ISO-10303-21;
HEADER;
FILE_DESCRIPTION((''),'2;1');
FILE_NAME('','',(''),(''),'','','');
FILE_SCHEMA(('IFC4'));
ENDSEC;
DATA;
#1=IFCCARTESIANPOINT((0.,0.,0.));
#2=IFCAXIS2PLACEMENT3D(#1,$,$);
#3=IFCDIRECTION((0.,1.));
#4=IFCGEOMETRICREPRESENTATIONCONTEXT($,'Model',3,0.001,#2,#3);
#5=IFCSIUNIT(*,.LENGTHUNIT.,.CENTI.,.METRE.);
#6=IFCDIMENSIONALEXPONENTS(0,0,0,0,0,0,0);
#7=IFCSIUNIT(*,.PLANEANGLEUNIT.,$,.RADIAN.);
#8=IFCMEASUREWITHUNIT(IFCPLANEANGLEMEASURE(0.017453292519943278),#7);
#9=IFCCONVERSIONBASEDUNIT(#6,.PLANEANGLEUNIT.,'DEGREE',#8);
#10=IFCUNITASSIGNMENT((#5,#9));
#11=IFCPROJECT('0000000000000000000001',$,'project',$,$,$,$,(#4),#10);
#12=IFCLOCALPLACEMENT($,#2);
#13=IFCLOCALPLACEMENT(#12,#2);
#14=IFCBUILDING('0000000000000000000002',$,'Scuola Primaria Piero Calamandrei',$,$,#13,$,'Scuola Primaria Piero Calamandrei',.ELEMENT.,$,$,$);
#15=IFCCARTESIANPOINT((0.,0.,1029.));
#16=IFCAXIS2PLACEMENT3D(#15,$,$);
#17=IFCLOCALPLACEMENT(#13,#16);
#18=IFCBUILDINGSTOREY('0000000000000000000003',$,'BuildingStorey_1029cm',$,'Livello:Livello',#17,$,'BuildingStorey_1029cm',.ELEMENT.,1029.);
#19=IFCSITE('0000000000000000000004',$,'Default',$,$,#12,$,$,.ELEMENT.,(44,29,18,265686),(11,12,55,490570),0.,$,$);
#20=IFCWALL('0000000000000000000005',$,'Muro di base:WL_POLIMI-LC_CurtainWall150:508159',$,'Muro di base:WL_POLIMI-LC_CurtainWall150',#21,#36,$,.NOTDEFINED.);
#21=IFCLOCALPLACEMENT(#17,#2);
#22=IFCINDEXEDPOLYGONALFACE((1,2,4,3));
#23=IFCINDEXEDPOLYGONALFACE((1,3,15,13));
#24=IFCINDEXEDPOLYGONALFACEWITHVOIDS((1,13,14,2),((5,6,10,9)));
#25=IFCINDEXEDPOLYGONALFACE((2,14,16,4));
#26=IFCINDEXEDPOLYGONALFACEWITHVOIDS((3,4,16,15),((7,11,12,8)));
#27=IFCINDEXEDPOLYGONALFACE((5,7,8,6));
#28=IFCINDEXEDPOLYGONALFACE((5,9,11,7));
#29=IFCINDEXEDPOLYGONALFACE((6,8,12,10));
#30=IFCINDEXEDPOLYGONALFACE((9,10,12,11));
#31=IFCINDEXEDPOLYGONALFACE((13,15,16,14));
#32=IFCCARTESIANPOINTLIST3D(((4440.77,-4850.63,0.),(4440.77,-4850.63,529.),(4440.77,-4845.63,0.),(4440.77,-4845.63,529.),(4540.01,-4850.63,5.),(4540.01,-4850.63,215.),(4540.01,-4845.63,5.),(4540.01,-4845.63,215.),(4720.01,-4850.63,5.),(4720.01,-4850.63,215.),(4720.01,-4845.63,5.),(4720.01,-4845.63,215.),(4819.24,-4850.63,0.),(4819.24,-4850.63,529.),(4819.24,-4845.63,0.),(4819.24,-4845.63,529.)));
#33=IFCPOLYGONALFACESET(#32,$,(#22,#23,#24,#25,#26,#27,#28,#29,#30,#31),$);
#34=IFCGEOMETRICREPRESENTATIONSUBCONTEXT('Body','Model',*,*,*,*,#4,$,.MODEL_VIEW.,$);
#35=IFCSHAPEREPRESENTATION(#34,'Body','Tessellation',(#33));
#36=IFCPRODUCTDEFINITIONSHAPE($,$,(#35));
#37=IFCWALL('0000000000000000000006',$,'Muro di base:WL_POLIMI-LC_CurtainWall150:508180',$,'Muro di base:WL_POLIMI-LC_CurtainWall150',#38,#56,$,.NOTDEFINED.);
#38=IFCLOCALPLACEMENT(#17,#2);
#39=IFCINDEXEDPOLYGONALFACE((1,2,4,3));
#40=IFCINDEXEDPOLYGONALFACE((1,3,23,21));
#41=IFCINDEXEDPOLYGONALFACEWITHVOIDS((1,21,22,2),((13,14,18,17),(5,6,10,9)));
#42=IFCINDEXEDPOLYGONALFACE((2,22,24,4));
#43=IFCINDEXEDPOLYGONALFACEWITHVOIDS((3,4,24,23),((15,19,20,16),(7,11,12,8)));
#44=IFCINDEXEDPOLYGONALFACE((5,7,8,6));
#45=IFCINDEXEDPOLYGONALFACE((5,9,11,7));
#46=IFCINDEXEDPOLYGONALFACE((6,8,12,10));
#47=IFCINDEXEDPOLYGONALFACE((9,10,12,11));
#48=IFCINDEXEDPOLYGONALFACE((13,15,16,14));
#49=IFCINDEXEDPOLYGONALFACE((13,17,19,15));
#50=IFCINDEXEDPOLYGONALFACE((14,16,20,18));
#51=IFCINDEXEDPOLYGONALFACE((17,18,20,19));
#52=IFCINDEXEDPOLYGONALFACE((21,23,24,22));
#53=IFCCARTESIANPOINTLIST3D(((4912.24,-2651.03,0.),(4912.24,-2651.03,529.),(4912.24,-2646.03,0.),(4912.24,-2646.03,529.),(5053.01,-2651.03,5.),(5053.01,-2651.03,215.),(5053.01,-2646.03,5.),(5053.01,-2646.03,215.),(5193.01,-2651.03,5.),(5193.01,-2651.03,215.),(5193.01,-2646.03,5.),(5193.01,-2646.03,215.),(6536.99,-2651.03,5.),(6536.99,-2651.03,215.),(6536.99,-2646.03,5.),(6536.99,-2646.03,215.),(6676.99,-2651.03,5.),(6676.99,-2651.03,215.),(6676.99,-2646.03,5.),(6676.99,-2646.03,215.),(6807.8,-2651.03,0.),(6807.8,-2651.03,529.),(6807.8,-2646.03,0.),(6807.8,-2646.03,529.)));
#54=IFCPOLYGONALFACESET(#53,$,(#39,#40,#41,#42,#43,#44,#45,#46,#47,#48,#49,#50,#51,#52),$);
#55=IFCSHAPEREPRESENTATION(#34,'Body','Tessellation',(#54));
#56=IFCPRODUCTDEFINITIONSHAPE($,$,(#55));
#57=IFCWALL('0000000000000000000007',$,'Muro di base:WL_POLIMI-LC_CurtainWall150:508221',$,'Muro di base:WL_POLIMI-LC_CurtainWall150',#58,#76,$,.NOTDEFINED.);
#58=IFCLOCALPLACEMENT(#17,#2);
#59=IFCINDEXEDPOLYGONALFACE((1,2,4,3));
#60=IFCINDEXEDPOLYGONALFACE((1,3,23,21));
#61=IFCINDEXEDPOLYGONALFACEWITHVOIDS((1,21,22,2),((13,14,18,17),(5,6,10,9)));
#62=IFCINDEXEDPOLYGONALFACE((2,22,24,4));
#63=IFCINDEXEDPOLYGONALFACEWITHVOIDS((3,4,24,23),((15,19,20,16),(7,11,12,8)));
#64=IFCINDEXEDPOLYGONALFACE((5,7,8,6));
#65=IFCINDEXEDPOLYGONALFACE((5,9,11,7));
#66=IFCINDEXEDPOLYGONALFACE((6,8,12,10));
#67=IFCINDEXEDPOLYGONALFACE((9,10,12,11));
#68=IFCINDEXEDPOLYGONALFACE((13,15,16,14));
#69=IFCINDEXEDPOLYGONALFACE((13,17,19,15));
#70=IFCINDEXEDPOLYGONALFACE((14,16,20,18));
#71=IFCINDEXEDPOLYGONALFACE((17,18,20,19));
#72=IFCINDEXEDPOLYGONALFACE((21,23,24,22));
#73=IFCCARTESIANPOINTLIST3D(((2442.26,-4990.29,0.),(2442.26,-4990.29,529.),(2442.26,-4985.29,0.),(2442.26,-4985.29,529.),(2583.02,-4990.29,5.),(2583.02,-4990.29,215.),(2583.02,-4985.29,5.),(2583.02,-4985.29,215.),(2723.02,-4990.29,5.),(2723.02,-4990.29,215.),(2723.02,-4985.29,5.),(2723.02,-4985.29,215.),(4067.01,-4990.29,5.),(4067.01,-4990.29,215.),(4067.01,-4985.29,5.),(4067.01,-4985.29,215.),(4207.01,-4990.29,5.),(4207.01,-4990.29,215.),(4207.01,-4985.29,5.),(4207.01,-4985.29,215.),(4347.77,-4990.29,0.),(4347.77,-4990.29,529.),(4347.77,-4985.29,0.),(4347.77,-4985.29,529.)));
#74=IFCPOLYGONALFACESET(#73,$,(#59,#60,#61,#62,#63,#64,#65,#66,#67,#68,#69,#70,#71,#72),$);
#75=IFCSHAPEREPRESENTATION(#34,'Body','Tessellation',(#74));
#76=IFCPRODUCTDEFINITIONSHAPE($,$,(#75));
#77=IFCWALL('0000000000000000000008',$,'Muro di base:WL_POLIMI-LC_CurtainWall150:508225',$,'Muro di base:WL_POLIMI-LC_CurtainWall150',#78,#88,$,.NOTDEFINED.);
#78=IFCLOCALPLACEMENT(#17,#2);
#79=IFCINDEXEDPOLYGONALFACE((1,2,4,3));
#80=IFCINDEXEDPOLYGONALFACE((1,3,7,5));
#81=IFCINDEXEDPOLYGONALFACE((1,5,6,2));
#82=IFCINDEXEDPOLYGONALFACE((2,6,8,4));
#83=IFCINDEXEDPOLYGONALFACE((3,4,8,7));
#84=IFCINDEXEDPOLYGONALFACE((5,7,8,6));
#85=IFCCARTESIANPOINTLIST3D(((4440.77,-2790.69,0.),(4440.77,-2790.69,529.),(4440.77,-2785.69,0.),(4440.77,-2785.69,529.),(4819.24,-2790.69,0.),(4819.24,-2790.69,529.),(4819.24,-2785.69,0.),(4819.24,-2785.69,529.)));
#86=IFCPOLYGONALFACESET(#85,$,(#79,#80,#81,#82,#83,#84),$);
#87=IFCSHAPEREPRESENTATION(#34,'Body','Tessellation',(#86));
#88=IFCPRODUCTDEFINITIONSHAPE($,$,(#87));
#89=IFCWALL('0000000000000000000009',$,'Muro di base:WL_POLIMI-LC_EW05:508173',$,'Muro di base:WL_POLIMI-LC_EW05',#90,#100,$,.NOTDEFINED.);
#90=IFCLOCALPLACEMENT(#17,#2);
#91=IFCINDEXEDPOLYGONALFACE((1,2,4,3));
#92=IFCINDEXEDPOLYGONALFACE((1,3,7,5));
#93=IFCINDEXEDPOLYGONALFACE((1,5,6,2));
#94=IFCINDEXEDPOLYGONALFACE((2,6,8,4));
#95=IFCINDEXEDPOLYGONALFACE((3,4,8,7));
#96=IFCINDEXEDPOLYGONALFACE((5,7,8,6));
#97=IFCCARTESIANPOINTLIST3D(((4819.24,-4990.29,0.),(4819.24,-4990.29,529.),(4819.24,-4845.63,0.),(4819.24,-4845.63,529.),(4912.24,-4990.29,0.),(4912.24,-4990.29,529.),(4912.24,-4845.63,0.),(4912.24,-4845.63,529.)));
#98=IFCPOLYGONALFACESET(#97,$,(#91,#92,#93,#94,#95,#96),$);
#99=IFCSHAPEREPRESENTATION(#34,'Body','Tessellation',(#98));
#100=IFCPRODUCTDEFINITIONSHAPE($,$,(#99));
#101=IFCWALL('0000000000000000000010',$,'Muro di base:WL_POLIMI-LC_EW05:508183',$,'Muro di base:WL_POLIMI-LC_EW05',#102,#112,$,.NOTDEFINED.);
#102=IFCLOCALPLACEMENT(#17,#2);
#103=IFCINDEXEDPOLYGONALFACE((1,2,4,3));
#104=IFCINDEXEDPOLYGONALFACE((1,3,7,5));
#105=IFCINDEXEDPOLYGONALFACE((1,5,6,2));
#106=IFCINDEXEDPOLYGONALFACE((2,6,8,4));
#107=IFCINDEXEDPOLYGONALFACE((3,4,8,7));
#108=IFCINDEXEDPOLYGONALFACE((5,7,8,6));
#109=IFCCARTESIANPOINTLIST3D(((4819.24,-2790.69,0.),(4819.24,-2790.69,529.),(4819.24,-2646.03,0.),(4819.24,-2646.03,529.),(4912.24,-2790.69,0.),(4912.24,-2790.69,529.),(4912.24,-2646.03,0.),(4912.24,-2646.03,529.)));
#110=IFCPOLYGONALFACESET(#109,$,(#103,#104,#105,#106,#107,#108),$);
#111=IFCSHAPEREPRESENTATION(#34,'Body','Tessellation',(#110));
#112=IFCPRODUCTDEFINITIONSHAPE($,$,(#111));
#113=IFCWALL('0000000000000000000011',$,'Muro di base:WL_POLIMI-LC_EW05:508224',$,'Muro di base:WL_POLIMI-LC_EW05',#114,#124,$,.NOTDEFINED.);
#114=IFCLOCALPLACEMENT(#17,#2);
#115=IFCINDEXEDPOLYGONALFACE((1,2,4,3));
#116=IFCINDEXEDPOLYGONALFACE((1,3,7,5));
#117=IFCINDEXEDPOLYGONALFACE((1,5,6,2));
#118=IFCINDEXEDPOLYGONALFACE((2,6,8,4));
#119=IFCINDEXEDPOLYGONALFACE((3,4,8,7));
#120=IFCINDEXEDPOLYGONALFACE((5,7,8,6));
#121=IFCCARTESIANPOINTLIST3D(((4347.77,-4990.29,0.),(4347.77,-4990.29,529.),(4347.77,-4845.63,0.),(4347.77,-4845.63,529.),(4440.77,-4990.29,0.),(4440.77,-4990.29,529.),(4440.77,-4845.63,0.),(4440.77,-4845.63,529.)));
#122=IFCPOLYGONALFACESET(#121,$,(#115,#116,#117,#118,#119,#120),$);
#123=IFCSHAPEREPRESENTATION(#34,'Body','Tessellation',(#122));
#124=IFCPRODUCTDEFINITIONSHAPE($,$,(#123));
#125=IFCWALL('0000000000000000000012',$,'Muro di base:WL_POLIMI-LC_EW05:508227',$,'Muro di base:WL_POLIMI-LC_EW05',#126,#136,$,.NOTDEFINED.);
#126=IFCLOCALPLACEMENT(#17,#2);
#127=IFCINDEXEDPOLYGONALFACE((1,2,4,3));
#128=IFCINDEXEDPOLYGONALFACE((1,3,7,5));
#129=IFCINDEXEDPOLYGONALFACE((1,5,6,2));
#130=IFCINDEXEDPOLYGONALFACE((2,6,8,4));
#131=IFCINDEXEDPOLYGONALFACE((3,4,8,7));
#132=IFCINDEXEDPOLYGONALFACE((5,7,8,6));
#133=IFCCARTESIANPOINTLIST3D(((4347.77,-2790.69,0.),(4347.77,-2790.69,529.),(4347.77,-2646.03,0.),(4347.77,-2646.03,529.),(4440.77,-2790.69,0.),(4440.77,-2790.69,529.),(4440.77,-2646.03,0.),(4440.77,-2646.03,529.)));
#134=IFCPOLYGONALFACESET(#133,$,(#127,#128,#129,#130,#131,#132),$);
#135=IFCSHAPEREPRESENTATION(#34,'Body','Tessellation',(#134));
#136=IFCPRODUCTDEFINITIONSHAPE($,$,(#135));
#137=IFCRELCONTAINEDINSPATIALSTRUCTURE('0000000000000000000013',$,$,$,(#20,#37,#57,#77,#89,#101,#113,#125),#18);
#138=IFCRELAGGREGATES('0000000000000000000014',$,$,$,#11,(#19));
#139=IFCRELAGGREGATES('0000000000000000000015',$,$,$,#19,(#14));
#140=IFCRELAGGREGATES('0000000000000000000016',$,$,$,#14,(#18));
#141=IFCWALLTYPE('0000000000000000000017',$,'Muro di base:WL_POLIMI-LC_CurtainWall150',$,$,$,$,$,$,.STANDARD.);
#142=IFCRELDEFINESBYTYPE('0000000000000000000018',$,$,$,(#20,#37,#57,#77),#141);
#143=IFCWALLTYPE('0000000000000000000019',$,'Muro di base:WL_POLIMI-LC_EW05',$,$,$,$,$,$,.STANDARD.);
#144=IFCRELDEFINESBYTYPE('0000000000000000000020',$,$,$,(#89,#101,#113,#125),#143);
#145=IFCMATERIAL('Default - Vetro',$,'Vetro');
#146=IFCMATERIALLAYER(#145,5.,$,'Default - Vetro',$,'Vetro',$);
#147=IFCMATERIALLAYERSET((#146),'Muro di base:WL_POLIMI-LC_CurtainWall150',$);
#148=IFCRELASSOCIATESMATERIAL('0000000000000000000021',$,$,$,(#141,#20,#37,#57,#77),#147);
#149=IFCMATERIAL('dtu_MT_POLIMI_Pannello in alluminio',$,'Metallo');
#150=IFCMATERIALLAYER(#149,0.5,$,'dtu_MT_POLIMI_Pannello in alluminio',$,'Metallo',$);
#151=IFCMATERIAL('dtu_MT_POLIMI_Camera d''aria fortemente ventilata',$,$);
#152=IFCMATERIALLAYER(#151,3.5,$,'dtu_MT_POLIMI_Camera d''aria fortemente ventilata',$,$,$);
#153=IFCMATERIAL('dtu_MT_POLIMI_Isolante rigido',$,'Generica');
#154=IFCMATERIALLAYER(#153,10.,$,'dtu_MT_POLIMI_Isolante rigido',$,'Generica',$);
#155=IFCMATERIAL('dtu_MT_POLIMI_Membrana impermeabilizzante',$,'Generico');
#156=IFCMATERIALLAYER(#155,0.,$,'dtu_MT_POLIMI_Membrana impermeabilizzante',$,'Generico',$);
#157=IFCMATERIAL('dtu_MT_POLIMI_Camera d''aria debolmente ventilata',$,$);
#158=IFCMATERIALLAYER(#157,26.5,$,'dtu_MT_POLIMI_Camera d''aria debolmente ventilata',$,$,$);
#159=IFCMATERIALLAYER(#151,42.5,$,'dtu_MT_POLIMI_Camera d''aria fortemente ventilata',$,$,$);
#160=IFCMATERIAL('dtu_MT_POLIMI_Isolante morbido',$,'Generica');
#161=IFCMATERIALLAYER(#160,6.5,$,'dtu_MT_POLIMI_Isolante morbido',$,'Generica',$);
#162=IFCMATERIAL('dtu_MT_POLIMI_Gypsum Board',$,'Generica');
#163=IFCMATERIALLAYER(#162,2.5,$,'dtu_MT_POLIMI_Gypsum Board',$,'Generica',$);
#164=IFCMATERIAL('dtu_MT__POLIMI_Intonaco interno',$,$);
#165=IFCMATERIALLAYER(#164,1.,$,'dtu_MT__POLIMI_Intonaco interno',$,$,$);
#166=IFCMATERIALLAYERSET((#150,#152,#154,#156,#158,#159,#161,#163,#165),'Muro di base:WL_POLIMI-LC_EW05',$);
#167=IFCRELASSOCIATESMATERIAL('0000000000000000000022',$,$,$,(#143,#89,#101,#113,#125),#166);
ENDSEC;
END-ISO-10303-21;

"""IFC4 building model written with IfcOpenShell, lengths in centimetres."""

from ifc_helpers import new_model, entity, si_unit, converted_unit, direction, frame, frame_2d, origin, place, context, subcontext, project, spatial, rectangle, extrude, material, layer, layer_set, layer_usage, type_object, element, save


model = new_model("IFC4")

# Units and contexts
model_context = context("Model", 3, precision=0.001, world=origin(), true_north=direction((0.0, 1.0)))
body_context = subcontext(model_context, "Body", "Model", "MODEL_VIEW")
ifc_project = project(units=[si_unit("LENGTHUNIT", "METRE", prefix="CENTI"), converted_unit("PLANEANGLEUNIT", "DEGREE", entity("IfcPlaneAngleMeasure", 0.017453292519943278), si_unit("PLANEANGLEUNIT", "RADIAN"), dimensions=[0, 0, 0, 0, 0, 0, 0])], contexts=[model_context])

# Site, building, storey
site_placement = place(None, origin())
site = spatial("IfcSite", under=ifc_project, at=site_placement, Name="Default", CompositionType="ELEMENT", RefLatitude=(44, 29, 18, 265686), RefLongitude=(11, 12, 55, 490570), RefElevation=0.0)
building_placement = place(site_placement, origin())
building = spatial("IfcBuilding", under=site, at=building_placement, Name="Scuola Primaria Piero Calamandrei", LongName="Scuola Primaria Piero Calamandrei", CompositionType="ELEMENT")
storey_placement = place(building_placement, frame((0.0, 0.0, 1029.0)))
storey = spatial("IfcBuildingStorey", under=building, at=storey_placement, Name="BuildingStorey_1029cm", ObjectType="Livello:Livello", LongName="BuildingStorey_1029cm", CompositionType="ELEMENT", Elevation=1029.0)

# Walls, openings
ifc_material_1 = material(Name="Default - Vetro", Category="Vetro")
ifc_layer_1 = layer(ifc_material_1, 5.0, Name="Default - Vetro", Category="Vetro")
ifc_layer_set_1 = layer_set([ifc_layer_1], Name="Muro di base:WL_POLIMI-LC_CurtainWall150")
ifc_layer_usage_1 = layer_usage(ifc_layer_set_1, "AXIS2", "NEGATIVE", 2.5)
wall_type_1 = type_object("IfcWallType", Name="Muro di base:WL_POLIMI-LC_CurtainWall150", PredefinedType="STANDARD", material=ifc_layer_set_1)
wall_1_placement = place(storey_placement, frame((4819.24, -4848.13, 0.0), z_axis=(0.0, 0.0, 1.0), x_axis=(-1.0, 0.0, 0.0)))
wall_1 = element("IfcWall", 1, at=wall_1_placement, inside=storey, type_object=wall_type_1, material=ifc_layer_usage_1, Name="Muro di base:WL_POLIMI-LC_CurtainWall150:508159", ObjectType="Muro di base:WL_POLIMI-LC_CurtainWall150", PredefinedType="NOTDEFINED", context=body_context, shape_type="SweptSolid", body=[
    extrude(rectangle(XDim=5.0, YDim=378.47, at=frame_2d((0.5, -37.69), x_axis=(1.0, 0.0))), frame((151.54, -0.5, 0.0), z_axis=(0.0, 0.0, 1.0), x_axis=(0.0, 1.0, 0.0)), (0.0, 0.0, 1.0), 529.0),
])
opening_1_placement = place(storey_placement, frame((4819.24, -4848.13, 0.0), z_axis=(0.0, 0.0, 1.0), x_axis=(-1.0, 0.0, 0.0)))
element("IfcOpeningElement", 2, at=opening_1_placement, cuts=wall_1, PredefinedType="OPENING", context=body_context, shape_type="SweptSolid", body=[
    extrude(rectangle(XDim=210.0, YDim=180.0, at=frame_2d((0.0, 0.0), x_axis=(0.0, 1.0))), frame((189.23, -2.5, 110.0), z_axis=(0.0, 1.0, 0.0), x_axis=(1.0, 0.0, 0.0)), (0.0, 0.0, 1.0), 5.0),
])
opening_2_placement = place(wall_1_placement, frame((99.23, -2.5, 5.0)))
element("IfcOpeningElement", 3, at=opening_2_placement, cuts=wall_1, PredefinedType="OPENING", context=body_context, shape_type="SweptSolid", body=[
    extrude(rectangle(XDim=210.0, YDim=180.0, at=frame_2d((105.0, 90.0), x_axis=(-1.0, 0.0))), frame((0.0, 0.0, 0.0), z_axis=(0.0, 1.0, 0.0), x_axis=(0.0, 0.0, 1.0)), (0.0, 0.0, 1.0), 5.0),
])
ifc_layer_usage_2 = layer_usage(ifc_layer_set_1, "AXIS2", "NEGATIVE", 2.5)
wall_2_placement = place(storey_placement, frame((4912.24, -2648.53, 0.0)))
wall_2 = element("IfcWall", 4, at=wall_2_placement, inside=storey, type_object=wall_type_1, material=ifc_layer_usage_2, Name="Muro di base:WL_POLIMI-LC_CurtainWall150:508180", ObjectType="Muro di base:WL_POLIMI-LC_CurtainWall150", PredefinedType="NOTDEFINED", context=body_context, shape_type="SweptSolid", body=[
    extrude(rectangle(XDim=1895.56, YDim=5.0, at=frame_2d((947.78, 0.0), x_axis=(-1.0, 0.0))), origin(), (0.0, 0.0, 1.0), 529.0),
])
opening_3_placement = place(wall_2_placement, frame((1624.75, -2.5, 5.0)))
element("IfcOpeningElement", 5, at=opening_3_placement, cuts=wall_2, PredefinedType="OPENING", context=body_context, shape_type="SweptSolid", body=[
    extrude(rectangle(XDim=210.0, YDim=140.0, at=frame_2d((105.0, 70.0), x_axis=(-1.0, 0.0))), frame((0.0, 0.0, 0.0), z_axis=(0.0, 1.0, 0.0), x_axis=(0.0, 0.0, 1.0)), (0.0, 0.0, 1.0), 5.0),
])
opening_4_placement = place(wall_2_placement, frame((140.77, -2.5, 5.0)))
element("IfcOpeningElement", 6, at=opening_4_placement, cuts=wall_2, PredefinedType="OPENING", context=body_context, shape_type="SweptSolid", body=[
    extrude(rectangle(XDim=210.0, YDim=140.0, at=frame_2d((105.0, 70.0), x_axis=(-1.0, 0.0))), frame((0.0, 0.0, 0.0), z_axis=(0.0, 1.0, 0.0), x_axis=(0.0, 0.0, 1.0)), (0.0, 0.0, 1.0), 5.0),
])
ifc_layer_usage_3 = layer_usage(ifc_layer_set_1, "AXIS2", "NEGATIVE", 2.5)
wall_3_placement = place(storey_placement, frame((4347.77, -4987.79, 0.0), z_axis=(0.0, 0.0, 1.0), x_axis=(-1.0, 0.0, 0.0)))
wall_3 = element("IfcWall", 7, at=wall_3_placement, inside=storey, type_object=wall_type_1, material=ifc_layer_usage_3, Name="Muro di base:WL_POLIMI-LC_CurtainWall150:508221", ObjectType="Muro di base:WL_POLIMI-LC_CurtainWall150", PredefinedType="NOTDEFINED", context=body_context, shape_type="SweptSolid", body=[
    extrude(rectangle(XDim=1905.52, YDim=5.0, at=frame_2d((952.76, 0.0), x_axis=(-1.0, 0.0))), origin(), (0.0, 0.0, 1.0), 529.0),
])
opening_5_placement = place(wall_3_placement, frame((1624.75, -2.5, 5.0)))
element("IfcOpeningElement", 8, at=opening_5_placement, cuts=wall_3, PredefinedType="OPENING", context=body_context, shape_type="SweptSolid", body=[
    extrude(rectangle(XDim=210.0, YDim=140.0, at=frame_2d((105.0, 70.0), x_axis=(-1.0, 0.0))), frame((0.0, 0.0, 0.0), z_axis=(0.0, 1.0, 0.0), x_axis=(0.0, 0.0, 1.0)), (0.0, 0.0, 1.0), 5.0),
])
opening_6_placement = place(wall_3_placement, frame((140.77, -2.5, 5.0)))
element("IfcOpeningElement", 9, at=opening_6_placement, cuts=wall_3, PredefinedType="OPENING", context=body_context, shape_type="SweptSolid", body=[
    extrude(rectangle(XDim=210.0, YDim=140.0, at=frame_2d((105.0, 70.0), x_axis=(-1.0, 0.0))), frame((0.0, 0.0, 0.0), z_axis=(0.0, 1.0, 0.0), x_axis=(0.0, 0.0, 1.0)), (0.0, 0.0, 1.0), 5.0),
])

# Walls
ifc_layer_usage_4 = layer_usage(ifc_layer_set_1, "AXIS2", "NEGATIVE", 2.5)
wall_4_placement = place(storey_placement, frame((4440.77, -2788.19, 0.0)))
element("IfcWall", 10, at=wall_4_placement, inside=storey, type_object=wall_type_1, material=ifc_layer_usage_4, Name="Muro di base:WL_POLIMI-LC_CurtainWall150:508225", ObjectType="Muro di base:WL_POLIMI-LC_CurtainWall150", PredefinedType="NOTDEFINED", context=body_context, shape_type="SweptSolid", body=[
    extrude(rectangle(XDim=5.0, YDim=378.47, at=frame_2d((0.0, 0.0), x_axis=(1.0, 0.0))), frame((189.23, 0.0, 0.0), z_axis=(0.0, 0.0, 1.0), x_axis=(0.0, 1.0, 0.0)), (0.0, 0.0, 1.0), 529.0),
])
ifc_material_2 = material(Name="dtu_MT_POLIMI_Pannello in alluminio", Category="Metallo")
ifc_layer_2 = layer(ifc_material_2, 0.5, Name="dtu_MT_POLIMI_Pannello in alluminio", Category="Metallo")
ifc_material_3 = material(Name="dtu_MT_POLIMI_Camera d'aria fortemente ventilata")
ifc_layer_3 = layer(ifc_material_3, 3.5, Name="dtu_MT_POLIMI_Camera d'aria fortemente ventilata")
ifc_material_4 = material(Name="dtu_MT_POLIMI_Isolante rigido", Category="Generica")
ifc_layer_4 = layer(ifc_material_4, 10.0, Name="dtu_MT_POLIMI_Isolante rigido", Category="Generica")
ifc_material_5 = material(Name="dtu_MT_POLIMI_Membrana impermeabilizzante", Category="Generico")
ifc_layer_5 = layer(ifc_material_5, 0.0, Name="dtu_MT_POLIMI_Membrana impermeabilizzante", Category="Generico")
ifc_material_6 = material(Name="dtu_MT_POLIMI_Camera d'aria debolmente ventilata")
ifc_layer_6 = layer(ifc_material_6, 26.5, Name="dtu_MT_POLIMI_Camera d'aria debolmente ventilata")
ifc_layer_7 = layer(ifc_material_3, 42.5, Name="dtu_MT_POLIMI_Camera d'aria fortemente ventilata")
ifc_material_7 = material(Name="dtu_MT_POLIMI_Isolante morbido", Category="Generica")
ifc_layer_8 = layer(ifc_material_7, 6.5, Name="dtu_MT_POLIMI_Isolante morbido", Category="Generica")
ifc_material_8 = material(Name="dtu_MT_POLIMI_Gypsum Board", Category="Generica")
ifc_layer_9 = layer(ifc_material_8, 2.5, Name="dtu_MT_POLIMI_Gypsum Board", Category="Generica")
ifc_material_9 = material(Name="dtu_MT__POLIMI_Intonaco interno")
ifc_layer_10 = layer(ifc_material_9, 1.0, Name="dtu_MT__POLIMI_Intonaco interno")
ifc_layer_set_2 = layer_set([ifc_layer_2, ifc_layer_3, ifc_layer_4, ifc_layer_5, ifc_layer_6, ifc_layer_7, ifc_layer_8, ifc_layer_9, ifc_layer_10], Name="Muro di base:WL_POLIMI-LC_EW05")
ifc_layer_usage_5 = layer_usage(ifc_layer_set_2, "AXIS2", "NEGATIVE", 46.5)
wall_type_2 = type_object("IfcWallType", Name="Muro di base:WL_POLIMI-LC_EW05", PredefinedType="STANDARD", material=ifc_layer_set_2)
wall_5_placement = place(storey_placement, frame((4865.74, -4990.29, 0.0), z_axis=(0.0, 0.0, 1.0), x_axis=(0.0, 1.0, 0.0)))
element("IfcWall", 11, at=wall_5_placement, inside=storey, type_object=wall_type_2, material=ifc_layer_usage_5, Name="Muro di base:WL_POLIMI-LC_EW05:508173", ObjectType="Muro di base:WL_POLIMI-LC_EW05", PredefinedType="NOTDEFINED", context=body_context, shape_type="SweptSolid", body=[
    extrude(rectangle(XDim=144.66, YDim=93.0, at=frame_2d((72.33, 0.0), x_axis=(-1.0, 0.0))), origin(), (0.0, 0.0, 1.0), 529.0),
])
ifc_layer_usage_6 = layer_usage(ifc_layer_set_2, "AXIS2", "NEGATIVE", 46.5)
wall_6_placement = place(storey_placement, frame((4865.74, -2790.69, 0.0), z_axis=(0.0, 0.0, 1.0), x_axis=(0.0, 1.0, 0.0)))
element("IfcWall", 12, at=wall_6_placement, inside=storey, type_object=wall_type_2, material=ifc_layer_usage_6, Name="Muro di base:WL_POLIMI-LC_EW05:508183", ObjectType="Muro di base:WL_POLIMI-LC_EW05", PredefinedType="NOTDEFINED", context=body_context, shape_type="SweptSolid", body=[
    extrude(rectangle(XDim=144.66, YDim=93.0, at=frame_2d((72.33, 0.0), x_axis=(-1.0, 0.0))), origin(), (0.0, 0.0, 1.0), 529.0),
])
ifc_layer_usage_7 = layer_usage(ifc_layer_set_2, "AXIS2", "NEGATIVE", 46.5)
wall_7_placement = place(storey_placement, frame((4394.27, -4845.63, 0.0), z_axis=(0.0, 0.0, 1.0), x_axis=(0.0, -1.0, 0.0)))
element("IfcWall", 13, at=wall_7_placement, inside=storey, type_object=wall_type_2, material=ifc_layer_usage_7, Name="Muro di base:WL_POLIMI-LC_EW05:508224", ObjectType="Muro di base:WL_POLIMI-LC_EW05", PredefinedType="NOTDEFINED", context=body_context, shape_type="SweptSolid", body=[
    extrude(rectangle(XDim=144.66, YDim=93.0, at=frame_2d((72.33, 0.0), x_axis=(-1.0, 0.0))), origin(), (0.0, 0.0, 1.0), 529.0),
])
ifc_layer_usage_8 = layer_usage(ifc_layer_set_2, "AXIS2", "NEGATIVE", 46.5)
wall_8_placement = place(storey_placement, frame((4394.27, -2646.03, 0.0), z_axis=(0.0, 0.0, 1.0), x_axis=(0.0, -1.0, 0.0)))
element("IfcWall", 14, at=wall_8_placement, inside=storey, type_object=wall_type_2, material=ifc_layer_usage_8, Name="Muro di base:WL_POLIMI-LC_EW05:508227", ObjectType="Muro di base:WL_POLIMI-LC_EW05", PredefinedType="NOTDEFINED", context=body_context, shape_type="SweptSolid", body=[
    extrude(rectangle(XDim=144.66, YDim=93.0, at=frame_2d((72.33, 0.0), x_axis=(-1.0, 0.0))), origin(), (0.0, 0.0, 1.0), 529.0),
])

save(model, "model.ifc")
